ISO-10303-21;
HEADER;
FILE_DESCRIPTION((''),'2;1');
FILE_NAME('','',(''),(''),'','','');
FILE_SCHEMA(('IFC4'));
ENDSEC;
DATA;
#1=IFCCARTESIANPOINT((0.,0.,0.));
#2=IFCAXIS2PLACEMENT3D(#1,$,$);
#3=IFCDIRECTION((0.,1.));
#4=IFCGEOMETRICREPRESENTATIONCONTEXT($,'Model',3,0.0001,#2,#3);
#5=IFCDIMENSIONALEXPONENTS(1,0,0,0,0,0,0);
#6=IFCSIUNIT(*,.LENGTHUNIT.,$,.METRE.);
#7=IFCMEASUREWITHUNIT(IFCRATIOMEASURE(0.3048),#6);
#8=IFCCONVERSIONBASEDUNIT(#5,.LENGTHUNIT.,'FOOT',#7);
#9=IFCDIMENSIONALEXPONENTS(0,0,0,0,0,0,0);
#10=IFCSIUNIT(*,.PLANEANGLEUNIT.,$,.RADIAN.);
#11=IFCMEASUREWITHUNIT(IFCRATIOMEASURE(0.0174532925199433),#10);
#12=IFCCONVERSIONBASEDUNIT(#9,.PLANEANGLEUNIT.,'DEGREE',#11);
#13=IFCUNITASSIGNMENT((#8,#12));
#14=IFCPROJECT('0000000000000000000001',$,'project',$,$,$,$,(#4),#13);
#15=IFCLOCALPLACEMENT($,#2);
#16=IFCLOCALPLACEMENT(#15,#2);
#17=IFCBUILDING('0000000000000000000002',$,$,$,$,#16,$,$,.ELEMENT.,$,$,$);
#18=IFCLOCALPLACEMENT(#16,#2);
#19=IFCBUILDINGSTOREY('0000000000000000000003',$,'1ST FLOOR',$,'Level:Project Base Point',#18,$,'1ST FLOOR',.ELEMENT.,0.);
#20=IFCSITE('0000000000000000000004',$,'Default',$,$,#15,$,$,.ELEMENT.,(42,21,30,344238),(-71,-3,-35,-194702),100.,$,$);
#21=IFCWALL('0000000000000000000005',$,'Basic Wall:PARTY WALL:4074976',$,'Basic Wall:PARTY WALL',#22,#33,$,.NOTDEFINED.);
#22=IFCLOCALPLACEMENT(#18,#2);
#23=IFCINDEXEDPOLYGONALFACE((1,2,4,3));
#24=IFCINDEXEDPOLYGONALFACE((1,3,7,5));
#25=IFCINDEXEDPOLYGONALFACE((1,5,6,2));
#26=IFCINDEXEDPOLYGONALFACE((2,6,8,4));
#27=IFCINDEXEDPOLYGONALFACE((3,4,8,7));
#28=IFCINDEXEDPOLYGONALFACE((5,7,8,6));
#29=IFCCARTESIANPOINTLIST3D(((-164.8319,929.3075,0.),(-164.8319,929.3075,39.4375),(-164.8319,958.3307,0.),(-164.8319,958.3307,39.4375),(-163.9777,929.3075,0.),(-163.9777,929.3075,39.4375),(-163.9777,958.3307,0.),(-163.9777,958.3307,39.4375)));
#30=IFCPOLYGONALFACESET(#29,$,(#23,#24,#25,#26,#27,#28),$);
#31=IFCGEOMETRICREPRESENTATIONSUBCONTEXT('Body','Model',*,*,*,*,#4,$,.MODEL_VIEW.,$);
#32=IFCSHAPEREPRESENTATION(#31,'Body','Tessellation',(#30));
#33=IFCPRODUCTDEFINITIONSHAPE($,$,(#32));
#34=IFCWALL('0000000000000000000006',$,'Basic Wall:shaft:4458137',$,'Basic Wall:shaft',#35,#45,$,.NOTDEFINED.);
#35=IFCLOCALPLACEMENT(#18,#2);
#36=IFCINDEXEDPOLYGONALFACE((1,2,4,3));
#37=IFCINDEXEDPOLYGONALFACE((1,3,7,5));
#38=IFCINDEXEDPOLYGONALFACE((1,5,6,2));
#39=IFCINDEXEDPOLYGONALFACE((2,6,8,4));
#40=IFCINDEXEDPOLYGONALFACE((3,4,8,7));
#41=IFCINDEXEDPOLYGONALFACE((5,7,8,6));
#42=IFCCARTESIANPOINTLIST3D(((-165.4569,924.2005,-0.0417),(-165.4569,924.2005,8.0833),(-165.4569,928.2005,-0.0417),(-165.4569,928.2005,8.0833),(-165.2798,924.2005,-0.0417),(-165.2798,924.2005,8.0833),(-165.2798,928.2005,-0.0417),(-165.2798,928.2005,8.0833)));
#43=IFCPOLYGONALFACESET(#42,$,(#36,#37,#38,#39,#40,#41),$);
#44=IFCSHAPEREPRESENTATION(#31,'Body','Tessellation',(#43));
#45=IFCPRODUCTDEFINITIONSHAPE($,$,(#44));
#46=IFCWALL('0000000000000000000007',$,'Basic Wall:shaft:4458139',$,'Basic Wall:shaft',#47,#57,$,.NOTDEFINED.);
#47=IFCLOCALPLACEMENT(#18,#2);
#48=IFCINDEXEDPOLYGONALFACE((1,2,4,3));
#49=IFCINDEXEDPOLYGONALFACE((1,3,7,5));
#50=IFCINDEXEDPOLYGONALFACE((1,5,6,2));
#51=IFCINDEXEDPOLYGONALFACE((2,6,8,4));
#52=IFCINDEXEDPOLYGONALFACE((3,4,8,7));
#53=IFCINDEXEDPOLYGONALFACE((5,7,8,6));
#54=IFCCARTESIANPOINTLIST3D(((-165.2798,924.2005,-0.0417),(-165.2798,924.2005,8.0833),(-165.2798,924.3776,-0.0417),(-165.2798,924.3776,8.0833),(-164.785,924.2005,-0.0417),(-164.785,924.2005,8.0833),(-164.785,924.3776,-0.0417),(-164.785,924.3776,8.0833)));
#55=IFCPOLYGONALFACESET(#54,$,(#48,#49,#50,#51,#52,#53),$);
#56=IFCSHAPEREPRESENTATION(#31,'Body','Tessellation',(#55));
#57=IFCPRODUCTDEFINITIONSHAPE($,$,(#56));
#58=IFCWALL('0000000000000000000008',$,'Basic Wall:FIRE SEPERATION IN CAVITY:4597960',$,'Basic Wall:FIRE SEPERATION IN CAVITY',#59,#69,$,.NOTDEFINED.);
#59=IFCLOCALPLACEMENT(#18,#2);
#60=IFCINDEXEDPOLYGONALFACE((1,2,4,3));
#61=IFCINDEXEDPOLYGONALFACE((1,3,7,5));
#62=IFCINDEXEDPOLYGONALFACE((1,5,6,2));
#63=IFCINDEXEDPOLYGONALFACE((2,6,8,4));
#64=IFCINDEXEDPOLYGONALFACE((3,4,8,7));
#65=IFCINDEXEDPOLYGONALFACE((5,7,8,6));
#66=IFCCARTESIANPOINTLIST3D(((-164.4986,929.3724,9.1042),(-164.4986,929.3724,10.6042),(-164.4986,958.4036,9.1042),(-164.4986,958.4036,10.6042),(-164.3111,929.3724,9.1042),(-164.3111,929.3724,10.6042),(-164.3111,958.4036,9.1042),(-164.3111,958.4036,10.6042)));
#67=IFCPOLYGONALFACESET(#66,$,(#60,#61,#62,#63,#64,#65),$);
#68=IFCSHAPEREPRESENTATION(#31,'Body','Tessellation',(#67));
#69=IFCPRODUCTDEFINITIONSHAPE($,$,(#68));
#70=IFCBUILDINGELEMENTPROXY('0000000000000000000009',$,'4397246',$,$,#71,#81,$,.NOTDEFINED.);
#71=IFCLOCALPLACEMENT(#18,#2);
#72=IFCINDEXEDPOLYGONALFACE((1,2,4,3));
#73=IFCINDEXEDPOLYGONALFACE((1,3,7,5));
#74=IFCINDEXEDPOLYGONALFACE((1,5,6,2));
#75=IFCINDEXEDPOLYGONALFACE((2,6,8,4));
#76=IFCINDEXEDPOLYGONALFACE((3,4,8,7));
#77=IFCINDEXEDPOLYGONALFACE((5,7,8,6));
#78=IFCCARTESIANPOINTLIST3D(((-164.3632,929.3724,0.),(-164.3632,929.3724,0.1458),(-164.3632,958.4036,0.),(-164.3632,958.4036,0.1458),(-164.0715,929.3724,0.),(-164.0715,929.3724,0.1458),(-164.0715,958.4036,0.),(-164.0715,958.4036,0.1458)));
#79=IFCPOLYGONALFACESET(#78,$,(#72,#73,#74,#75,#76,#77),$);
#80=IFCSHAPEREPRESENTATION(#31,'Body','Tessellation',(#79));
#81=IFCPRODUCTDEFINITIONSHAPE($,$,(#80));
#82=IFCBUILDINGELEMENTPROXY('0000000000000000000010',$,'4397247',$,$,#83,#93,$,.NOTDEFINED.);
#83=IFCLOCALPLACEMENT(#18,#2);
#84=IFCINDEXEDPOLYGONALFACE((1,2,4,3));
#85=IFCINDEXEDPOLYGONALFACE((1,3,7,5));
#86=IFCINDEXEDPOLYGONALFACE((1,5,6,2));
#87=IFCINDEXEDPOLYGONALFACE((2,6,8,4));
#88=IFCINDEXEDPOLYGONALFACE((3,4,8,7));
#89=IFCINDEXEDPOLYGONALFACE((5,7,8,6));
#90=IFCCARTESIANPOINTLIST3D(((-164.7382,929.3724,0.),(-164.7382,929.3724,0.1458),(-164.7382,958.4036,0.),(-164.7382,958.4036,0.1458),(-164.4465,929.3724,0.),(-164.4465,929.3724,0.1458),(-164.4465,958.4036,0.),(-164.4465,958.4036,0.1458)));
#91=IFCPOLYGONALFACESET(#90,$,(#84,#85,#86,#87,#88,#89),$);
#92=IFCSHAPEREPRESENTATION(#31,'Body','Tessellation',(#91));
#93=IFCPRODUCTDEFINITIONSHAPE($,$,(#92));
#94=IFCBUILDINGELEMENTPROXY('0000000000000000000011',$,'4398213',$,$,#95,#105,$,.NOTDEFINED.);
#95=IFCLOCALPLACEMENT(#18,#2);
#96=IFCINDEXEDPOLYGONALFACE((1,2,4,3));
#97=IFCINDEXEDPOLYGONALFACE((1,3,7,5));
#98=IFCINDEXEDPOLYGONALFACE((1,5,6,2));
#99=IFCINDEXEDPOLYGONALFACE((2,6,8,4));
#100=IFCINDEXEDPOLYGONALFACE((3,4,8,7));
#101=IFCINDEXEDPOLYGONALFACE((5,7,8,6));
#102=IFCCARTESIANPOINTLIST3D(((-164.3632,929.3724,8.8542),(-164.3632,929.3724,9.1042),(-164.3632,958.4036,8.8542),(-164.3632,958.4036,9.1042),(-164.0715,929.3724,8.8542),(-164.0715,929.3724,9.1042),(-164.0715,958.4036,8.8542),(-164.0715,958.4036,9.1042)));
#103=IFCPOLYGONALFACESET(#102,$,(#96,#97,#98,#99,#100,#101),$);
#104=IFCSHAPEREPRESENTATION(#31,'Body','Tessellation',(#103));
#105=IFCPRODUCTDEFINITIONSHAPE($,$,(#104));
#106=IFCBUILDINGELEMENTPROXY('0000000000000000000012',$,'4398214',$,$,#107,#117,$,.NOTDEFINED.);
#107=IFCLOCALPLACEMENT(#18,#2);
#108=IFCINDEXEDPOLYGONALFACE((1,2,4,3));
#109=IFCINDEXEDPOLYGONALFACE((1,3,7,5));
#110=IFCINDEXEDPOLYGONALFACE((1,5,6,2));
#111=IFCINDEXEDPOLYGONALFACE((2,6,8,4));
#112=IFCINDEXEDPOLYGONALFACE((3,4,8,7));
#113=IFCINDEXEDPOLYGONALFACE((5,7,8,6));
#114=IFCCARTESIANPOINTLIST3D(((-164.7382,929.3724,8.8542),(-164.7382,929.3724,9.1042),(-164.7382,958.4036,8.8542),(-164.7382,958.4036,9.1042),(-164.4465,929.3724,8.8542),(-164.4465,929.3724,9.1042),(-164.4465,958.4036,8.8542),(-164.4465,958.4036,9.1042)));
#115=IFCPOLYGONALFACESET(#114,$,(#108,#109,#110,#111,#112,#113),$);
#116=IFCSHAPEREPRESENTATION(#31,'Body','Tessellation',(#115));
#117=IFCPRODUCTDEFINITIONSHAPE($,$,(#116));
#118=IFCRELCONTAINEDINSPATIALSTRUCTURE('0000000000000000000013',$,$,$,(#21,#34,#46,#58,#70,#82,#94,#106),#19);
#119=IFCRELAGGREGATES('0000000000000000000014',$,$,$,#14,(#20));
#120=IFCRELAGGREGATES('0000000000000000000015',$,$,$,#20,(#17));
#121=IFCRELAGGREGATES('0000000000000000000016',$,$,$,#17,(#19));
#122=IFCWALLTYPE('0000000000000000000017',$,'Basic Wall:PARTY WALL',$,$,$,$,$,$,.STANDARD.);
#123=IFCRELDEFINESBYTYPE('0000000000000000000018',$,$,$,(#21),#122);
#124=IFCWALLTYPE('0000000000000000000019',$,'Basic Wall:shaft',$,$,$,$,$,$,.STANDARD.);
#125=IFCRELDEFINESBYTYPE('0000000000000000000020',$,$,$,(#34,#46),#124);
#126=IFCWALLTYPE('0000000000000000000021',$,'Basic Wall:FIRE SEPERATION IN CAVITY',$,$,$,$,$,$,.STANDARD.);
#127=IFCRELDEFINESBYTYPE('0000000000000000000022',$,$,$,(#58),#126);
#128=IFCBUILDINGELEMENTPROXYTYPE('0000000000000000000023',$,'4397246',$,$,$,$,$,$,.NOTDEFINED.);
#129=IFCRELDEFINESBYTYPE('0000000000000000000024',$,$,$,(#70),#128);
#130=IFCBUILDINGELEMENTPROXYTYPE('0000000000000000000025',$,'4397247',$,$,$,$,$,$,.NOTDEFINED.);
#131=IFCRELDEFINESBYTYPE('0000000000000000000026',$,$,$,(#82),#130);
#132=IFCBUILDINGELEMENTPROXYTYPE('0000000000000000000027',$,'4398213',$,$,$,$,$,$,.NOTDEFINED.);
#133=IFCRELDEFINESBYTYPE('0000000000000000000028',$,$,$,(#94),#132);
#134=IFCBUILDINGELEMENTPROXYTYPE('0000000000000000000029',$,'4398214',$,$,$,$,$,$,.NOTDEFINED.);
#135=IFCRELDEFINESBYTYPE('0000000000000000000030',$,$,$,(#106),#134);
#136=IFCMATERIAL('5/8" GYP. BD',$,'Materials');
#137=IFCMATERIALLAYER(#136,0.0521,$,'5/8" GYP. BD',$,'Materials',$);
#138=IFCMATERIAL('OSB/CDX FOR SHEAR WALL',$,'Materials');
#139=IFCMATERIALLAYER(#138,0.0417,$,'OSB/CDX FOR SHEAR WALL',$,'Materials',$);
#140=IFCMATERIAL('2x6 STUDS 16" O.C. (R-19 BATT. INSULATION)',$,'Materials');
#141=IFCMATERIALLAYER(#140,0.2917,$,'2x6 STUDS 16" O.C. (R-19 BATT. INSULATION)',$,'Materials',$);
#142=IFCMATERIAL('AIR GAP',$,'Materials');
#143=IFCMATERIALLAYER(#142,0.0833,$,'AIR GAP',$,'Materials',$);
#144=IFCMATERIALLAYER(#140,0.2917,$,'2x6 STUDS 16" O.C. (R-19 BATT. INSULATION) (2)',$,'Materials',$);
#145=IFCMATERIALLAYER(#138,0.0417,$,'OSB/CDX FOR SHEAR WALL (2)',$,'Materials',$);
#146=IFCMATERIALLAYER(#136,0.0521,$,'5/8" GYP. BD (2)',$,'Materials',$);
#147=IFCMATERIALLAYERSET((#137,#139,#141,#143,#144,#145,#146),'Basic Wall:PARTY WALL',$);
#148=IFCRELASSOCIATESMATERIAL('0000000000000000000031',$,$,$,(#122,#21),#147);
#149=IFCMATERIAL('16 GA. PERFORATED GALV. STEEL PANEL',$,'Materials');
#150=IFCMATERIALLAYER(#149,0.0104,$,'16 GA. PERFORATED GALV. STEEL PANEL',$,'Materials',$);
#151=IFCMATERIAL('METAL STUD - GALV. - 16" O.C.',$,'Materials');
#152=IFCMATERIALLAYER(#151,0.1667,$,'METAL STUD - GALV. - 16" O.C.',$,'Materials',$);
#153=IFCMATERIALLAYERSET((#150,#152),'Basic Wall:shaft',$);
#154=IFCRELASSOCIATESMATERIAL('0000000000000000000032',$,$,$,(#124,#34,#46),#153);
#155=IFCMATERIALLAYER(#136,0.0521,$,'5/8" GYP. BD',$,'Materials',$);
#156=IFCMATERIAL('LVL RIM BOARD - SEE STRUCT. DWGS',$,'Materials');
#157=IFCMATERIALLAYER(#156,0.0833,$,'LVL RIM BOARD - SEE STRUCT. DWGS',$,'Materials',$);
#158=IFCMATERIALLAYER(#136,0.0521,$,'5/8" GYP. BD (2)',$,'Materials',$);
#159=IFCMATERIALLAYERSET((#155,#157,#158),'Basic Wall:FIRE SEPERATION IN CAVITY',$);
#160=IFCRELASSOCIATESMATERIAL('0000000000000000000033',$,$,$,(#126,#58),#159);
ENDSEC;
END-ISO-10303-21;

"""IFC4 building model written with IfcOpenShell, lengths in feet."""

from ifc_helpers import new_model, entity, si_unit, converted_unit, direction, frame, frame_2d, origin, origin_2d_with_axis, place, context, subcontext, project, spatial, rectangle, extrude, material, layer, layer_set, layer_usage, type_object, element, save


model = new_model("IFC4")

# Units and contexts
model_context = context("Model", 3, precision=0.0001, world=origin(), true_north=direction((0.0, 1.0)))
body_context = subcontext(model_context, "Body", "Model", "MODEL_VIEW")
ifc_project = project(units=[converted_unit("LENGTHUNIT", "FOOT", entity("IfcRatioMeasure", 0.3048), si_unit("LENGTHUNIT", "METRE"), dimensions=[1, 0, 0, 0, 0, 0, 0]), converted_unit("PLANEANGLEUNIT", "DEGREE", entity("IfcRatioMeasure", 0.0174532925199433), si_unit("PLANEANGLEUNIT", "RADIAN"), dimensions=[0, 0, 0, 0, 0, 0, 0])], contexts=[model_context])

# Site, building, storey
site_placement = place(None, origin())
site = spatial("IfcSite", under=ifc_project, at=site_placement, Name="Default", CompositionType="ELEMENT", RefLatitude=(42, 21, 30, 344238), RefLongitude=(-71, -3, -35, -194702), RefElevation=100.0)
building_placement = place(site_placement, origin())
building = spatial("IfcBuilding", under=site, at=building_placement, CompositionType="ELEMENT")
storey_placement = place(building_placement, origin())
storey = spatial("IfcBuildingStorey", under=building, at=storey_placement, Name="1ST FLOOR", ObjectType="Level:Project Base Point", LongName="1ST FLOOR", CompositionType="ELEMENT", Elevation=0.0)

# Shared definitions
ifc_material_1 = material(Name="2x6 STUDS 16\" O.C. (R-19 BATT. INSULATION)", Category="Materials")

# Shared definitions
ifc_material_2 = material(Name="5/8\" GYP. BD", Category="Materials")

# Walls
ifc_layer_1 = layer(ifc_material_2, 0.0521, Name="5/8\" GYP. BD", Category="Materials")
ifc_material_3 = material(Name="OSB/CDX FOR SHEAR WALL", Category="Materials")
ifc_layer_2 = layer(ifc_material_3, 0.0417, Name="OSB/CDX FOR SHEAR WALL", Category="Materials")
ifc_layer_3 = layer(ifc_material_1, 0.2917, Name="2x6 STUDS 16\" O.C. (R-19 BATT. INSULATION)", Category="Materials")
ifc_material_4 = material(Name="AIR GAP", Category="Materials")
ifc_layer_4 = layer(ifc_material_4, 0.0833, Name="AIR GAP", Category="Materials")
ifc_layer_5 = layer(ifc_material_1, 0.2917, Name="2x6 STUDS 16\" O.C. (R-19 BATT. INSULATION) (2)", Category="Materials")
ifc_layer_6 = layer(ifc_material_3, 0.0417, Name="OSB/CDX FOR SHEAR WALL (2)", Category="Materials")
ifc_layer_7 = layer(ifc_material_2, 0.0521, Name="5/8\" GYP. BD (2)", Category="Materials")
ifc_layer_set_1 = layer_set([ifc_layer_1, ifc_layer_2, ifc_layer_3, ifc_layer_4, ifc_layer_5, ifc_layer_6, ifc_layer_7], Name="Basic Wall:PARTY WALL")
ifc_layer_usage_1 = layer_usage(ifc_layer_set_1, "AXIS2", "NEGATIVE", 0.4271)
wall_type_1 = type_object("IfcWallType", Name="Basic Wall:PARTY WALL", PredefinedType="STANDARD", material=ifc_layer_set_1)
wall_1_placement = place(storey_placement, frame((-164.4048, 929.3075, 0.0), z_axis=(0.0, 0.0, 1.0), x_axis=(0.0, 1.0, 0.0)))
element("IfcWall", 1, at=wall_1_placement, inside=storey, type_object=wall_type_1, material=ifc_layer_usage_1, Name="Basic Wall:PARTY WALL:4074976", ObjectType="Basic Wall:PARTY WALL", PredefinedType="NOTDEFINED", context=body_context, shape_type="SweptSolid", body=[
    extrude(rectangle(XDim=29.0231, YDim=0.8542, at=frame_2d((14.5116, 0.0), x_axis=(-1.0, 0.0))), origin(), (0.0, 0.0, 1.0), 39.4375),
])
ifc_material_5 = material(Name="16 GA. PERFORATED GALV. STEEL PANEL", Category="Materials")
ifc_layer_8 = layer(ifc_material_5, 0.0104, Name="16 GA. PERFORATED GALV. STEEL PANEL", Category="Materials")
ifc_material_6 = material(Name="METAL STUD - GALV. - 16\" O.C.", Category="Materials")
ifc_layer_9 = layer(ifc_material_6, 0.1667, Name="METAL STUD - GALV. - 16\" O.C.", Category="Materials")
ifc_layer_set_2 = layer_set([ifc_layer_8, ifc_layer_9], Name="Basic Wall:shaft")
ifc_layer_usage_2 = layer_usage(ifc_layer_set_2, "AXIS2", "POSITIVE", -0.0885)
wall_type_2 = type_object("IfcWallType", Name="Basic Wall:shaft", PredefinedType="STANDARD", material=ifc_layer_set_2)
wall_2_placement = place(storey_placement, frame((-165.3684, 928.2005, -0.0417), z_axis=(0.0, 0.0, 1.0), x_axis=(0.0, -1.0, 0.0)))
element("IfcWall", 2, at=wall_2_placement, inside=storey, type_object=wall_type_2, material=ifc_layer_usage_2, Name="Basic Wall:shaft:4458137", ObjectType="Basic Wall:shaft", PredefinedType="NOTDEFINED", context=body_context, shape_type="SweptSolid", body=[
    extrude(rectangle(XDim=4.0, YDim=0.1771, at=frame_2d((2.0, 0.0), x_axis=(-1.0, 0.0))), origin(), (0.0, 0.0, 1.0), 8.125),
])
ifc_layer_usage_3 = layer_usage(ifc_layer_set_2, "AXIS2", "NEGATIVE", 0.0885)
wall_3_placement = place(storey_placement, frame((-164.785, 924.289, -0.0417), z_axis=(0.0, 0.0, 1.0), x_axis=(-1.0, 0.0, 0.0)))
element("IfcWall", 3, at=wall_3_placement, inside=storey, type_object=wall_type_2, material=ifc_layer_usage_3, Name="Basic Wall:shaft:4458139", ObjectType="Basic Wall:shaft", PredefinedType="NOTDEFINED", context=body_context, shape_type="SweptSolid", body=[
    extrude(rectangle(XDim=0.4948, YDim=0.1771, at=frame_2d((0.2474, 0.0), x_axis=(-1.0, 0.0))), origin(), (0.0, 0.0, 1.0), 8.125),
])
ifc_layer_10 = layer(ifc_material_2, 0.0521, Name="5/8\" GYP. BD", Category="Materials")
ifc_material_7 = material(Name="LVL RIM BOARD - SEE STRUCT. DWGS", Category="Materials")
ifc_layer_11 = layer(ifc_material_7, 0.0833, Name="LVL RIM BOARD - SEE STRUCT. DWGS", Category="Materials")
ifc_layer_12 = layer(ifc_material_2, 0.0521, Name="5/8\" GYP. BD (2)", Category="Materials")
ifc_layer_set_3 = layer_set([ifc_layer_10, ifc_layer_11, ifc_layer_12], Name="Basic Wall:FIRE SEPERATION IN CAVITY")
ifc_layer_usage_4 = layer_usage(ifc_layer_set_3, "AXIS2", "POSITIVE", -0.0938)
wall_type_3 = type_object("IfcWallType", Name="Basic Wall:FIRE SEPERATION IN CAVITY", PredefinedType="STANDARD", material=ifc_layer_set_3)
wall_4_placement = place(storey_placement, frame((-164.4048, 929.3724, 9.1042), z_axis=(0.0, 0.0, 1.0), x_axis=(0.0, 1.0, 0.0)))
element("IfcWall", 4, at=wall_4_placement, inside=storey, type_object=wall_type_3, material=ifc_layer_usage_4, Name="Basic Wall:FIRE SEPERATION IN CAVITY:4597960", ObjectType="Basic Wall:FIRE SEPERATION IN CAVITY", PredefinedType="NOTDEFINED", context=body_context, shape_type="SweptSolid", body=[
    extrude(rectangle(XDim=29.0313, YDim=0.1875, at=frame_2d((14.5156, 0.0), x_axis=(-1.0, 0.0))), origin(), (0.0, 0.0, 1.0), 1.5),
])

# Building element proxies
building_element_proxy_type_1 = type_object("IfcBuildingElementProxyType", Name="4397246", PredefinedType="NOTDEFINED")
proxy_1_placement = place(storey_placement, frame((-164.3632, 929.3724, 0.0)))
element("IfcBuildingElementProxy", 5, at=proxy_1_placement, inside=storey, type_object=building_element_proxy_type_1, Name="4397246", PredefinedType="NOTDEFINED", context=body_context, shape_type="SweptSolid", body=[
    extrude(rectangle(XDim=29.0313, YDim=0.2917, at=origin_2d_with_axis()), frame((0.1458, 14.5156, 0.0), z_axis=(0.0, 0.0, 1.0), x_axis=(0.0, 1.0, 0.0)), (0.0, 0.0, 1.0), 0.1458),
])
building_element_proxy_type_2 = type_object("IfcBuildingElementProxyType", Name="4397247", PredefinedType="NOTDEFINED")
proxy_2_placement = place(storey_placement, frame((-164.7382, 929.3724, 0.0)))
element("IfcBuildingElementProxy", 6, at=proxy_2_placement, inside=storey, type_object=building_element_proxy_type_2, Name="4397247", PredefinedType="NOTDEFINED", context=body_context, shape_type="SweptSolid", body=[
    extrude(rectangle(XDim=29.0313, YDim=0.2917, at=origin_2d_with_axis()), frame((0.1458, 14.5156, 0.0), z_axis=(0.0, 0.0, 1.0), x_axis=(0.0, 1.0, 0.0)), (0.0, 0.0, 1.0), 0.1458),
])
building_element_proxy_type_3 = type_object("IfcBuildingElementProxyType", Name="4398213", PredefinedType="NOTDEFINED")
proxy_3_placement = place(storey_placement, frame((-164.3632, 929.3724, 8.8542)))
element("IfcBuildingElementProxy", 7, at=proxy_3_placement, inside=storey, type_object=building_element_proxy_type_3, Name="4398213", PredefinedType="NOTDEFINED", context=body_context, shape_type="SweptSolid", body=[
    extrude(rectangle(XDim=29.0313, YDim=0.2917, at=origin_2d_with_axis()), frame((0.1458, 14.5156, 0.0), z_axis=(0.0, 0.0, 1.0), x_axis=(0.0, 1.0, 0.0)), (0.0, 0.0, 1.0), 0.25),
])
building_element_proxy_type_4 = type_object("IfcBuildingElementProxyType", Name="4398214", PredefinedType="NOTDEFINED")
proxy_4_placement = place(storey_placement, frame((-164.7382, 929.3724, 8.8542)))
element("IfcBuildingElementProxy", 8, at=proxy_4_placement, inside=storey, type_object=building_element_proxy_type_4, Name="4398214", PredefinedType="NOTDEFINED", context=body_context, shape_type="SweptSolid", body=[
    extrude(rectangle(XDim=29.0313, YDim=0.2917, at=origin_2d_with_axis()), frame((0.1458, 14.5156, 0.0), z_axis=(0.0, 0.0, 1.0), x_axis=(0.0, 1.0, 0.0)), (0.0, 0.0, 1.0), 0.25),
])

save(model, "model.ifc")
